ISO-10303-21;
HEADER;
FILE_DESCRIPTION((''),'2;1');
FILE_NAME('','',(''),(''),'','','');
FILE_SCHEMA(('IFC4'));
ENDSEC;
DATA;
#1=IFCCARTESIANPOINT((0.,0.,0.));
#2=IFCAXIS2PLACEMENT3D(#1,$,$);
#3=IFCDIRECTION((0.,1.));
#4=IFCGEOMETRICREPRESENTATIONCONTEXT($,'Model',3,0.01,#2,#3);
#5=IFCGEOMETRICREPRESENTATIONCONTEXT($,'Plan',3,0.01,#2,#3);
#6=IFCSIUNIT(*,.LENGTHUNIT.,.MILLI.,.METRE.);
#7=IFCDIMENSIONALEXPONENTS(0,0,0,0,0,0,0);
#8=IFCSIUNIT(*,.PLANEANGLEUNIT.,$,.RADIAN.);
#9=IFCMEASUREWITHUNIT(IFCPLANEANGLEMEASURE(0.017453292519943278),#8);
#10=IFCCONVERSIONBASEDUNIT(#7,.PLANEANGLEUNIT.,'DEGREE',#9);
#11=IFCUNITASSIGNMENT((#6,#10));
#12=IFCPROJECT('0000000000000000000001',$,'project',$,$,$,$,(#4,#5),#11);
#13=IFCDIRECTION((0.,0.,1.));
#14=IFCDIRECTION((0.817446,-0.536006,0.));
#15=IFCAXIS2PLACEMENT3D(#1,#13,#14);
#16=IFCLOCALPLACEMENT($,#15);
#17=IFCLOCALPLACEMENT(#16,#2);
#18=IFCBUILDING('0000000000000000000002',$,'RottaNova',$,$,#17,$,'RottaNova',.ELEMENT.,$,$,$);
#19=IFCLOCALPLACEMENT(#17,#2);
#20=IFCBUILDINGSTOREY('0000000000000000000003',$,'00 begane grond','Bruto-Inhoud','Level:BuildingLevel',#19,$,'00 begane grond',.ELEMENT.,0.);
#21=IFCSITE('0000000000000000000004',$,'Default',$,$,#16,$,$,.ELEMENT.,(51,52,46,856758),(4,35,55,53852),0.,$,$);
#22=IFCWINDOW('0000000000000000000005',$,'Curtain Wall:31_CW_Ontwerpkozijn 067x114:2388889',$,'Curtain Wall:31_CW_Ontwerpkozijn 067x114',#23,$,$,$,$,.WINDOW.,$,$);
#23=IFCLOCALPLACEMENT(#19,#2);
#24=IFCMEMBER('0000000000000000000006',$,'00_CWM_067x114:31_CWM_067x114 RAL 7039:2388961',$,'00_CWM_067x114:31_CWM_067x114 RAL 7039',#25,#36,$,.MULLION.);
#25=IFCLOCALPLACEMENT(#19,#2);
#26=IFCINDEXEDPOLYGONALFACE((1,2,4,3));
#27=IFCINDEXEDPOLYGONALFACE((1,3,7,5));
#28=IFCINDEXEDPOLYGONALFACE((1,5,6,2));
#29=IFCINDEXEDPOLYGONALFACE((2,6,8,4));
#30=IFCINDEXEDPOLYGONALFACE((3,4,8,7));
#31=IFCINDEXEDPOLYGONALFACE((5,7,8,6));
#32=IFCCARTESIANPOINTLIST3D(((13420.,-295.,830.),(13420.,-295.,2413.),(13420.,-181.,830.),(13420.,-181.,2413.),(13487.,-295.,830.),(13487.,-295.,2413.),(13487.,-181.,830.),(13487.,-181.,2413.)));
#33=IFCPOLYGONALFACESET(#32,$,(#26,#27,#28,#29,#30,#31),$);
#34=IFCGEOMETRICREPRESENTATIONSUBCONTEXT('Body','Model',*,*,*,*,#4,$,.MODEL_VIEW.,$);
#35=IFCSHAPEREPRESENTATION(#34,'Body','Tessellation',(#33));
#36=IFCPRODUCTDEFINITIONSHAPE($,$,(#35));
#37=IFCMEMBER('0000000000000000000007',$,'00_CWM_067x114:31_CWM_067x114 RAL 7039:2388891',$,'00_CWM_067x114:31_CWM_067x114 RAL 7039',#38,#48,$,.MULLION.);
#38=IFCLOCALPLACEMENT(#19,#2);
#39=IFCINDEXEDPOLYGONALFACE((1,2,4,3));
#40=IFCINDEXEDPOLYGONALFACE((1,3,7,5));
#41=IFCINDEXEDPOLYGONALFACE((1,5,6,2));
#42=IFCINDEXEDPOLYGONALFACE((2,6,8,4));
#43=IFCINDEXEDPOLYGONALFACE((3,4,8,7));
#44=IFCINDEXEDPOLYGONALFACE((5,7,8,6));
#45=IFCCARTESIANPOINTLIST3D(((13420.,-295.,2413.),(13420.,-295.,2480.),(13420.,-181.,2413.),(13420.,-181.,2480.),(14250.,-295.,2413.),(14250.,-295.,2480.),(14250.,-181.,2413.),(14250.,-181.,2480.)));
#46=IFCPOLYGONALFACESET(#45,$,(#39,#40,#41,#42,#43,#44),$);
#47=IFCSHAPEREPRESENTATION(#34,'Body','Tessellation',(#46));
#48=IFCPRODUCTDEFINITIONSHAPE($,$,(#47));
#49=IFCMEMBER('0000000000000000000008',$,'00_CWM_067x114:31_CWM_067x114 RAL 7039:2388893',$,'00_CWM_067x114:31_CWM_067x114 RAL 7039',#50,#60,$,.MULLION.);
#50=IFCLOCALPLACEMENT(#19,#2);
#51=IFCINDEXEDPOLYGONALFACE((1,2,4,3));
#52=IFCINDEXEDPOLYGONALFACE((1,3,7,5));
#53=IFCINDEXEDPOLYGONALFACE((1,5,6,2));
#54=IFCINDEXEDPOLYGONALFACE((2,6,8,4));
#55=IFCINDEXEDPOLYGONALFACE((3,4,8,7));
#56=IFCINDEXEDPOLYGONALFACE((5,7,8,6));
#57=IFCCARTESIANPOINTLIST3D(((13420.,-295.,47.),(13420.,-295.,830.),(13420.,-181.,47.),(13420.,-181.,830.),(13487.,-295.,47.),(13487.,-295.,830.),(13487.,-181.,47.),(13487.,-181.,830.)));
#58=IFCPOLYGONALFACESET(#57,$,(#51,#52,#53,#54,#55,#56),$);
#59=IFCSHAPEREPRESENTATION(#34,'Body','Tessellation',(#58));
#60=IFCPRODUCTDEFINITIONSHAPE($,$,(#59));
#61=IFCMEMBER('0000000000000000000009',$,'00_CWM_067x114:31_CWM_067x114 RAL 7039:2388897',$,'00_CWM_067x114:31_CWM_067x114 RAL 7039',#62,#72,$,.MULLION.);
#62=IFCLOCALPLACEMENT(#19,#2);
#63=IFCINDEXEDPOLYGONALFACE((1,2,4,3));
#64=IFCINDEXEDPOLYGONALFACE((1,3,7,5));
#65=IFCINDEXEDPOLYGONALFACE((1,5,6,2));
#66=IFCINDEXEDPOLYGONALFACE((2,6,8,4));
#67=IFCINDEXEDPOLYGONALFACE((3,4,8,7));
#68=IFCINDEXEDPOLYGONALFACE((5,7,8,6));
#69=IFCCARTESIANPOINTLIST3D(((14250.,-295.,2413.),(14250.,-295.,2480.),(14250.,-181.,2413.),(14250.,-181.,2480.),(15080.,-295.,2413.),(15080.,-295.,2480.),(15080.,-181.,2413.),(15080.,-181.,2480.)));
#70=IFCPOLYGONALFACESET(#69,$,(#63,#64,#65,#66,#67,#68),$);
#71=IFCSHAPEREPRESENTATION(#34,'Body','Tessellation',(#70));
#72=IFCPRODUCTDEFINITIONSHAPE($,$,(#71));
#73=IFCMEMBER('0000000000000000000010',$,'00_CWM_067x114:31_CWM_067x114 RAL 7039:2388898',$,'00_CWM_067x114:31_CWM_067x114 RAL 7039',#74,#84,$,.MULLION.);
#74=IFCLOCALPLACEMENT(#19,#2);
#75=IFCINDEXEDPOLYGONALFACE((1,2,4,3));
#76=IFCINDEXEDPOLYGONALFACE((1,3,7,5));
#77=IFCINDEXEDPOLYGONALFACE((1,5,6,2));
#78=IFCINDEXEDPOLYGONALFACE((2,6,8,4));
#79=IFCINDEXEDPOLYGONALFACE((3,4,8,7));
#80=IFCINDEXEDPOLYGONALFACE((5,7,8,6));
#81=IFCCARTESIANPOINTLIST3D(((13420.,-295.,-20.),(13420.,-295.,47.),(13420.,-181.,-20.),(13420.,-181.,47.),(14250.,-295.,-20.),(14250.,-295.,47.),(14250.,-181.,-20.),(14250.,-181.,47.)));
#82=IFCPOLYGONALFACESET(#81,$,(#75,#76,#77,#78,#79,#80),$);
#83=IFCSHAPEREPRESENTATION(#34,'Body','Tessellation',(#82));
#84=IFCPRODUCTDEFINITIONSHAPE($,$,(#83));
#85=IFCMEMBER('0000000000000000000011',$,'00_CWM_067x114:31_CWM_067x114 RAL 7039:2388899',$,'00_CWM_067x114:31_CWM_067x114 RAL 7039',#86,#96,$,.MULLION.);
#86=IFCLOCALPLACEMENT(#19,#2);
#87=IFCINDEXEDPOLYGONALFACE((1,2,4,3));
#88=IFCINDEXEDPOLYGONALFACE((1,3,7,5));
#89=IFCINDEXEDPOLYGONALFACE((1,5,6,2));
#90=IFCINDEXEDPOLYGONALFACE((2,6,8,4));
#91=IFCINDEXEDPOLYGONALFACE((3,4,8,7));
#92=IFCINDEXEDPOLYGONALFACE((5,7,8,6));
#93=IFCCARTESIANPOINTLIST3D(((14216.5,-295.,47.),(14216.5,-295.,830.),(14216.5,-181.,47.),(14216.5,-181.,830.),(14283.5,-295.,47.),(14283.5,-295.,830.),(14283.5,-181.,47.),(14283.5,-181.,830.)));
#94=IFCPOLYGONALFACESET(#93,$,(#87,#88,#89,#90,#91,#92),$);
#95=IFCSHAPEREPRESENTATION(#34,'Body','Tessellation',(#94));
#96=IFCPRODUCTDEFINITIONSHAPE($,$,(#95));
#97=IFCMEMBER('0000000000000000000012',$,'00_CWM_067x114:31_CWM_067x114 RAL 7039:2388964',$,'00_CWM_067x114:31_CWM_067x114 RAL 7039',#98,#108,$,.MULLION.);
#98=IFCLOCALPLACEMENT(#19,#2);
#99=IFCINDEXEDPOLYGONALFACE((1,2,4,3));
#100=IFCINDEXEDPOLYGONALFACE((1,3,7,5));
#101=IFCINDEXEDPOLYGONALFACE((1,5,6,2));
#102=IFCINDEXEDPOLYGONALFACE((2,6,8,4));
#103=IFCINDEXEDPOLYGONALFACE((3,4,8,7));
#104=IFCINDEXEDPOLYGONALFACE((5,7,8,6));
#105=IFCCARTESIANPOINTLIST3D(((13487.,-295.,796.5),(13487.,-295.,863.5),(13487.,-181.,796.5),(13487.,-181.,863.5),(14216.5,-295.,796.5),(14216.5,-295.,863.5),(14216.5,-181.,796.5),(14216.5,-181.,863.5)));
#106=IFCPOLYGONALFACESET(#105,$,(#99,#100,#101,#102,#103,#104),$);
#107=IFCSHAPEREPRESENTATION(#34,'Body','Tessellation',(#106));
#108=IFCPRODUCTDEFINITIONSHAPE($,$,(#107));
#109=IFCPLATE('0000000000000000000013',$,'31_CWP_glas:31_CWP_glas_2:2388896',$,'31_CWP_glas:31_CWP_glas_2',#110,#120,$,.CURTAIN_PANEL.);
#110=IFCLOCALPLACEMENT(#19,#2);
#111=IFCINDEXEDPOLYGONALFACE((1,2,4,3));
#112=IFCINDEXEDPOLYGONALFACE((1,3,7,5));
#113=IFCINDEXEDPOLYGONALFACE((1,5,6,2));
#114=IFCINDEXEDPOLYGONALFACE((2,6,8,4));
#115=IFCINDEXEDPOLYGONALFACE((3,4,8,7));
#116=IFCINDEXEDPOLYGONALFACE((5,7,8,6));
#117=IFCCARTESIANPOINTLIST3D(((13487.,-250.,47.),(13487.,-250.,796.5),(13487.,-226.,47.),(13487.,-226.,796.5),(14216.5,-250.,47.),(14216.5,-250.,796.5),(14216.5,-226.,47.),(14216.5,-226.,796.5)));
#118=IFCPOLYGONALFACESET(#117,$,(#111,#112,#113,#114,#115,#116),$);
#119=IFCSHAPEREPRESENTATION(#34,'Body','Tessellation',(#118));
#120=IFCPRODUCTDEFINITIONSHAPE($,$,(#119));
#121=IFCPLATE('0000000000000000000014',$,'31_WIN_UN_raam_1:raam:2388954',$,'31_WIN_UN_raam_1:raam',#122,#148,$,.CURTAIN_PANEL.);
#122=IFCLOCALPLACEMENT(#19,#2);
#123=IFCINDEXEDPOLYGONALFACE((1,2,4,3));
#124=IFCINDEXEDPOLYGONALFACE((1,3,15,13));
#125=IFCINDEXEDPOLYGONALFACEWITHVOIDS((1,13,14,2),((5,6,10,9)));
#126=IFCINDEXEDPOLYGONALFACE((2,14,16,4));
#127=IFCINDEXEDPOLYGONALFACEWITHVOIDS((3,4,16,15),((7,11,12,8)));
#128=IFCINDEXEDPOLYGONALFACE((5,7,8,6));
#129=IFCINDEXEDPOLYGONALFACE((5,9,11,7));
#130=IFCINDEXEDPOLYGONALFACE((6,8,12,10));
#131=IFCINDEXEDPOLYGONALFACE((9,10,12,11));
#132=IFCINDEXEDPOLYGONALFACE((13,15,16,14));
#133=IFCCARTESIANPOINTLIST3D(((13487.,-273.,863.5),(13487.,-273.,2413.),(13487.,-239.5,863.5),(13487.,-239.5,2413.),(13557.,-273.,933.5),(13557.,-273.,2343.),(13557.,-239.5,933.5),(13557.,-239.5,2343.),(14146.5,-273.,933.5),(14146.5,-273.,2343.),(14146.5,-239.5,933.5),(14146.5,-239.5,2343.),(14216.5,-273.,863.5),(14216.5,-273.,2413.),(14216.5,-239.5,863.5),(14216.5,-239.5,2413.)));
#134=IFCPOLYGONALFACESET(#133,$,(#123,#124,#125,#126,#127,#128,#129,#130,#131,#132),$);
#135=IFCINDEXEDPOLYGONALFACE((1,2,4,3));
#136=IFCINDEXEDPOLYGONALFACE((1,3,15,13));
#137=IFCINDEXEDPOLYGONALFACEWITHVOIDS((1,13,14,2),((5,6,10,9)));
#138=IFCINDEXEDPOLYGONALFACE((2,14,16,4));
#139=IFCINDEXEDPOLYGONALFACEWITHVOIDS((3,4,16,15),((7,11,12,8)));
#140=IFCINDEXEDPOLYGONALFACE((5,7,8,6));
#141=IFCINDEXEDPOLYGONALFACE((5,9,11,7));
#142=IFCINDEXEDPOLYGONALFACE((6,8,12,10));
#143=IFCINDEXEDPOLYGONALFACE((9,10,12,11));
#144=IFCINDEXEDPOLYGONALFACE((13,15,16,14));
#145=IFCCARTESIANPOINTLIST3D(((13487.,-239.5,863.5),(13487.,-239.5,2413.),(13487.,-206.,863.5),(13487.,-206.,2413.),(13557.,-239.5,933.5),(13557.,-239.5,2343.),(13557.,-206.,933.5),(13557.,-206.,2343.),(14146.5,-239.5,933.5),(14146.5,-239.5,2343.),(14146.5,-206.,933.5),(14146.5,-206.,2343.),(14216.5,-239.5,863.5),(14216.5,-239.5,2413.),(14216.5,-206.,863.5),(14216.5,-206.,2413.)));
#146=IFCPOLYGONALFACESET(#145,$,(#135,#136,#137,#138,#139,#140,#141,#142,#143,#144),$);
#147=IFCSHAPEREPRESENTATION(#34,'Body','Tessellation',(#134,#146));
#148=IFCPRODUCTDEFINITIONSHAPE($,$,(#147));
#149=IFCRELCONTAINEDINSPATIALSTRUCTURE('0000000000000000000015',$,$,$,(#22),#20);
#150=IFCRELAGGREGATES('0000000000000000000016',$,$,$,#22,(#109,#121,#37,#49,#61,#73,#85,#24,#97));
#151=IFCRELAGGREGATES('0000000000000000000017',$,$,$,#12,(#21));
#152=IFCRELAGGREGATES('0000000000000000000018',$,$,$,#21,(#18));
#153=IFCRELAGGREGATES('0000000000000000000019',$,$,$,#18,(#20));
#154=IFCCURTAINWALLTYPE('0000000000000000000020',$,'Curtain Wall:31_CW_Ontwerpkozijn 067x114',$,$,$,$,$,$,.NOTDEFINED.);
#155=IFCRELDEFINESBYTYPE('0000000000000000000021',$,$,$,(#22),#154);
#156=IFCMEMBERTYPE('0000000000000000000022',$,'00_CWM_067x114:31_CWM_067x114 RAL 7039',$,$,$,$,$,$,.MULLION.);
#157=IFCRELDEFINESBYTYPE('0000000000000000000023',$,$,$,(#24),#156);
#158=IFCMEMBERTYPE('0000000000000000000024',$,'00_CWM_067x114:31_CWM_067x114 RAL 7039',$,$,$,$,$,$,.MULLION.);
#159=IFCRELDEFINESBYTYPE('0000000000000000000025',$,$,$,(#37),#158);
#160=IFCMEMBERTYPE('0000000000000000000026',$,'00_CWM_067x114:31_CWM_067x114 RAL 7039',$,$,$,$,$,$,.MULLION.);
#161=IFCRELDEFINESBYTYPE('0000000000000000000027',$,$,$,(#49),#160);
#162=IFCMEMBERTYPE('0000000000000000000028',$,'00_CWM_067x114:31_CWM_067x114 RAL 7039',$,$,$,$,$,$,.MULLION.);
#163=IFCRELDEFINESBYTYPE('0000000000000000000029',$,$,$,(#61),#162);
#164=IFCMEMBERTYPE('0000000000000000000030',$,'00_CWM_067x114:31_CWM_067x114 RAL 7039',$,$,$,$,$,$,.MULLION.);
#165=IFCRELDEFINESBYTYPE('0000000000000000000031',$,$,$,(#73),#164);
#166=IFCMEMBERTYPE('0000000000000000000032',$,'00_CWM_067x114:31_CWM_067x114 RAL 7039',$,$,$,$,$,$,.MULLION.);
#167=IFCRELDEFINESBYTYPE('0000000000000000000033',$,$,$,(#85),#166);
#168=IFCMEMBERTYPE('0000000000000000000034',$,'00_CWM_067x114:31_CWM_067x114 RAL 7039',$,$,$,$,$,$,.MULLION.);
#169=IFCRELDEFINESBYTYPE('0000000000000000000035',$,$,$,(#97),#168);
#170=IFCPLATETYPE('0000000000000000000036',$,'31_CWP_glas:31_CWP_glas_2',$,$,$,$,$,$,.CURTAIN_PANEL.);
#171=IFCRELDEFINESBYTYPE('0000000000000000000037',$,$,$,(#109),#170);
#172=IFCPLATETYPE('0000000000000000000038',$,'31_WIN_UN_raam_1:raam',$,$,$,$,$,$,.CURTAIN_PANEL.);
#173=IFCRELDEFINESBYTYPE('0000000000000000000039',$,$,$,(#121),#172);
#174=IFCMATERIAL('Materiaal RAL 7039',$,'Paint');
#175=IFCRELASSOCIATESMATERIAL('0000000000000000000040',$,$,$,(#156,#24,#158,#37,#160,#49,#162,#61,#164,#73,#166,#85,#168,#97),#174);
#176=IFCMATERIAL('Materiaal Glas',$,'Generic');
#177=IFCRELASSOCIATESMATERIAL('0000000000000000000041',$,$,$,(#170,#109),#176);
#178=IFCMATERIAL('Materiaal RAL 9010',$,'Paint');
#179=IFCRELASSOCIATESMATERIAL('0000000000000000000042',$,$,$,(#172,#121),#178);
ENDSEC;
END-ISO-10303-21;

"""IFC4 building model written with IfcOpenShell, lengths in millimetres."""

from ifc_helpers import new_model, entity, si_unit, converted_unit, direction, frame, origin, place, context, subcontext, project, spatial, indexed_curve, outline, extrude, source, transform, mapped, material, type_object, type_shapes, element, aggregate, save


model = new_model("IFC4")

# Units and contexts
model_context = context("Model", 3, precision=0.01, world=origin(), true_north=direction((0.0, 1.0)))
plan_context = context("Plan", 3, precision=0.01, world=origin(), true_north=direction((0.0, 1.0)))
body_context = subcontext(model_context, "Body", "Model", "MODEL_VIEW")
ifc_project = project(units=[si_unit("LENGTHUNIT", "METRE", prefix="MILLI"), converted_unit("PLANEANGLEUNIT", "DEGREE", entity("IfcPlaneAngleMeasure", 0.017453292519943278), si_unit("PLANEANGLEUNIT", "RADIAN"), dimensions=[0, 0, 0, 0, 0, 0, 0])], contexts=[model_context, plan_context])

# Site, building, storey
site_placement = place(None, frame((0.0, 0.0, 0.0), z_axis=(0.0, 0.0, 1.0), x_axis=(0.817446, -0.536006, 0.0)))
site = spatial("IfcSite", under=ifc_project, at=site_placement, Name="Default", CompositionType="ELEMENT", RefLatitude=(51, 52, 46, 856758), RefLongitude=(4, 35, 55, 53852), RefElevation=0.0)
building_placement = place(site_placement, origin())
building = spatial("IfcBuilding", under=site, at=building_placement, Name="RottaNova", LongName="RottaNova", CompositionType="ELEMENT")
storey_placement = place(building_placement, origin())
storey = spatial("IfcBuildingStorey", under=building, at=storey_placement, Name="00 begane grond", Description="Bruto-Inhoud", ObjectType="Level:BuildingLevel", LongName="00 begane grond", CompositionType="ELEMENT", Elevation=0.0)

# Window, members, plates
curtain_wall_type = type_object("IfcCurtainWallType", Name="Curtain Wall:31_CW_Ontwerpkozijn 067x114", PredefinedType="NOTDEFINED")
window_1_placement = place(storey_placement, origin())
window_1 = element("IfcWindow", 1, at=window_1_placement, inside=storey, type_object=curtain_wall_type, Name="Curtain Wall:31_CW_Ontwerpkozijn 067x114:2388889", ObjectType="Curtain Wall:31_CW_Ontwerpkozijn 067x114", PredefinedType="WINDOW")
ifc_material_1 = material(Name="Materiaal RAL 7039", Category="Paint")
member_type_1 = type_object("IfcMemberType", Name="00_CWM_067x114:31_CWM_067x114 RAL 7039", PredefinedType="MULLION", material=ifc_material_1)
shared_shape_1 = source(origin(), body_context, "Body", "SweptSolid", [
    extrude(outline(indexed_curve([(-33.5, -57.0), (33.5, -57.0), (33.5, 57.0), (-33.5, 57.0), (-33.5, -57.0)], self_intersect=False)), frame((-33.5, -57.0, -1583.0), z_axis=(0.0, 0.0, 1.0), x_axis=(-1.0, 0.0, 0.0)), (0.0, 0.0, 1.0), 1583.0),
])
type_shapes(member_type_1, [shared_shape_1])
member_1_placement = place(window_1_placement, frame((13420.0, -181.0, 830.0), z_axis=(0.0, 0.0, -1.0), x_axis=(-1.0, 0.0, 0.0)))
member_1 = element("IfcMember", 2, at=member_1_placement, type_object=member_type_1, material=ifc_material_1, Name="00_CWM_067x114:31_CWM_067x114 RAL 7039:2388961", ObjectType="00_CWM_067x114:31_CWM_067x114 RAL 7039", PredefinedType="MULLION", context=body_context, shape_type="MappedRepresentation", body=[
    mapped(shared_shape_1, transform((0.0, 0.0, 0.0), scale=1.0)),
])
member_type_2 = type_object("IfcMemberType", Name="00_CWM_067x114:31_CWM_067x114 RAL 7039", PredefinedType="MULLION", material=ifc_material_1)
shared_shape_2 = source(origin(), body_context, "Body", "SweptSolid", [
    extrude(outline(indexed_curve([(-33.5, -57.0), (33.5, -57.0), (33.5, 57.0), (-33.5, 57.0), (-33.5, -57.0)], self_intersect=False)), frame((-33.5, -57.0, -830.0), z_axis=(0.0, 0.0, 1.0), x_axis=(-1.0, 0.0, 0.0)), (0.0, 0.0, 1.0), 830.0),
])
type_shapes(member_type_2, [shared_shape_2])
member_2_placement = place(window_1_placement, frame((13420.0, -181.0, 2480.0), z_axis=(-1.0, 0.0, 0.0), x_axis=(0.0, 0.0, 1.0)))
member_2 = element("IfcMember", 3, at=member_2_placement, type_object=member_type_2, material=ifc_material_1, Name="00_CWM_067x114:31_CWM_067x114 RAL 7039:2388891", ObjectType="00_CWM_067x114:31_CWM_067x114 RAL 7039", PredefinedType="MULLION", context=body_context, shape_type="MappedRepresentation", body=[
    mapped(shared_shape_2, transform((0.0, 0.0, 0.0), scale=1.0)),
])
member_type_3 = type_object("IfcMemberType", Name="00_CWM_067x114:31_CWM_067x114 RAL 7039", PredefinedType="MULLION", material=ifc_material_1)
shared_shape_3 = source(origin(), body_context, "Body", "SweptSolid", [
    extrude(outline(indexed_curve([(-33.5, -57.0), (33.5, -57.0), (33.5, 57.0), (-33.5, 57.0), (-33.5, -57.0)], self_intersect=False)), frame((-33.5, -57.0, -783.0), z_axis=(0.0, 0.0, 1.0), x_axis=(-1.0, 0.0, 0.0)), (0.0, 0.0, 1.0), 783.0),
])
type_shapes(member_type_3, [shared_shape_3])
member_3_placement = place(window_1_placement, frame((13420.0, -181.0, 47.0), z_axis=(0.0, 0.0, -1.0), x_axis=(-1.0, 0.0, 0.0)))
member_3 = element("IfcMember", 4, at=member_3_placement, type_object=member_type_3, material=ifc_material_1, Name="00_CWM_067x114:31_CWM_067x114 RAL 7039:2388893", ObjectType="00_CWM_067x114:31_CWM_067x114 RAL 7039", PredefinedType="MULLION", context=body_context, shape_type="MappedRepresentation", body=[
    mapped(shared_shape_3, transform((0.0, 0.0, 0.0), scale=1.0)),
])
member_type_4 = type_object("IfcMemberType", Name="00_CWM_067x114:31_CWM_067x114 RAL 7039", PredefinedType="MULLION", material=ifc_material_1)
shared_shape_4 = source(origin(), body_context, "Body", "SweptSolid", [
    extrude(outline(indexed_curve([(-33.5, -57.0), (33.5, -57.0), (33.5, 57.0), (-33.5, 57.0), (-33.5, -57.0)], self_intersect=False)), frame((-33.5, -57.0, -830.0), z_axis=(0.0, 0.0, 1.0), x_axis=(-1.0, 0.0, 0.0)), (0.0, 0.0, 1.0), 830.0),
])
type_shapes(member_type_4, [shared_shape_4])
member_4_placement = place(window_1_placement, frame((14250.0, -181.0, 2480.0), z_axis=(-1.0, 0.0, 0.0), x_axis=(0.0, 0.0, 1.0)))
member_4 = element("IfcMember", 5, at=member_4_placement, type_object=member_type_4, material=ifc_material_1, Name="00_CWM_067x114:31_CWM_067x114 RAL 7039:2388897", ObjectType="00_CWM_067x114:31_CWM_067x114 RAL 7039", PredefinedType="MULLION", context=body_context, shape_type="MappedRepresentation", body=[
    mapped(shared_shape_4, transform((0.0, 0.0, 0.0), scale=1.0)),
])
member_type_5 = type_object("IfcMemberType", Name="00_CWM_067x114:31_CWM_067x114 RAL 7039", PredefinedType="MULLION", material=ifc_material_1)
shared_shape_5 = source(origin(), body_context, "Body", "SweptSolid", [
    extrude(outline(indexed_curve([(-33.5, -57.0), (33.5, -57.0), (33.5, 57.0), (-33.5, 57.0), (-33.5, -57.0)], self_intersect=False)), frame((-33.5, -57.0, -830.0), z_axis=(0.0, 0.0, 1.0), x_axis=(-1.0, 0.0, 0.0)), (0.0, 0.0, 1.0), 830.0),
])
type_shapes(member_type_5, [shared_shape_5])
member_5_placement = place(window_1_placement, frame((14250.0, -181.0, -20.0), z_axis=(1.0, 0.0, 0.0), x_axis=(0.0, 0.0, -1.0)))
member_5 = element("IfcMember", 6, at=member_5_placement, type_object=member_type_5, material=ifc_material_1, Name="00_CWM_067x114:31_CWM_067x114 RAL 7039:2388898", ObjectType="00_CWM_067x114:31_CWM_067x114 RAL 7039", PredefinedType="MULLION", context=body_context, shape_type="MappedRepresentation", body=[
    mapped(shared_shape_5, transform((0.0, 0.0, 0.0), scale=1.0)),
])
member_type_6 = type_object("IfcMemberType", Name="00_CWM_067x114:31_CWM_067x114 RAL 7039", PredefinedType="MULLION", material=ifc_material_1)
shared_shape_6 = source(origin(), body_context, "Body", "SweptSolid", [
    extrude(outline(indexed_curve([(-33.5, -57.0), (33.5, -57.0), (33.5, 57.0), (-33.5, 57.0), (-33.5, -57.0)], self_intersect=False)), frame((0.0, -57.0, -783.0), z_axis=(0.0, 0.0, 1.0), x_axis=(-1.0, 0.0, 0.0)), (0.0, 0.0, 1.0), 783.0),
])
type_shapes(member_type_6, [shared_shape_6])
member_6_placement = place(window_1_placement, frame((14250.0, -181.0, 47.0), z_axis=(0.0, 0.0, -1.0), x_axis=(-1.0, 0.0, 0.0)))
member_6 = element("IfcMember", 7, at=member_6_placement, type_object=member_type_6, material=ifc_material_1, Name="00_CWM_067x114:31_CWM_067x114 RAL 7039:2388899", ObjectType="00_CWM_067x114:31_CWM_067x114 RAL 7039", PredefinedType="MULLION", context=body_context, shape_type="MappedRepresentation", body=[
    mapped(shared_shape_6, transform((0.0, 0.0, 0.0), scale=1.0)),
])
member_type_7 = type_object("IfcMemberType", Name="00_CWM_067x114:31_CWM_067x114 RAL 7039", PredefinedType="MULLION", material=ifc_material_1)
shared_shape_7 = source(origin(), body_context, "Body", "SweptSolid", [
    extrude(outline(indexed_curve([(-33.5, -57.0), (33.5, -57.0), (33.5, 57.0), (-33.5, 57.0), (-33.5, -57.0)], self_intersect=False)), frame((0.0, -57.0, -729.5), z_axis=(0.0, 0.0, 1.0), x_axis=(-1.0, 0.0, 0.0)), (0.0, 0.0, 1.0), 729.5),
])
type_shapes(member_type_7, [shared_shape_7])
member_7_placement = place(window_1_placement, frame((13487.0, -181.0, 830.0), z_axis=(-1.0, 0.0, 0.0), x_axis=(0.0, 0.0, 1.0)))
member_7 = element("IfcMember", 8, at=member_7_placement, type_object=member_type_7, material=ifc_material_1, Name="00_CWM_067x114:31_CWM_067x114 RAL 7039:2388964", ObjectType="00_CWM_067x114:31_CWM_067x114 RAL 7039", PredefinedType="MULLION", context=body_context, shape_type="MappedRepresentation", body=[
    mapped(shared_shape_7, transform((0.0, 0.0, 0.0), scale=1.0)),
])
ifc_material_2 = material(Name="Materiaal Glas", Category="Generic")
plate_type_1 = type_object("IfcPlateType", Name="31_CWP_glas:31_CWP_glas_2", PredefinedType="CURTAIN_PANEL", material=ifc_material_2)
shared_shape_8 = source(origin(), body_context, "Body", "SweptSolid", [
    extrude(outline(indexed_curve([(-12.0, -364.7), (12.0, -364.7), (12.0, 364.7), (-12.0, 364.7), (-12.0, -364.7)], self_intersect=False)), frame((0.0, 57.0, 0.0), z_axis=(0.0, 0.0, 1.0), x_axis=(0.0, 1.0, 0.0)), (0.0, 0.0, 1.0), 749.5),
])
type_shapes(plate_type_1, [shared_shape_8])
plate_1_placement = place(window_1_placement, frame((13851.8, -181.0, 47.0), z_axis=(0.0, 0.0, 1.0), x_axis=(-1.0, 0.0, 0.0)))
plate_1 = element("IfcPlate", 9, at=plate_1_placement, type_object=plate_type_1, material=ifc_material_2, Name="31_CWP_glas:31_CWP_glas_2:2388896", ObjectType="31_CWP_glas:31_CWP_glas_2", PredefinedType="CURTAIN_PANEL", context=body_context, shape_type="MappedRepresentation", body=[
    mapped(shared_shape_8, transform((0.0, 0.0, 0.0), scale=1.0)),
])
ifc_material_3 = material(Name="Materiaal RAL 9010", Category="Paint")
plate_type_2 = type_object("IfcPlateType", Name="31_WIN_UN_raam_1:raam", PredefinedType="CURTAIN_PANEL", material=ifc_material_3)
shared_shape_9 = source(origin(), body_context, "Body", "SweptSolid", [
    extrude(outline(indexed_curve([(-364.7, -774.7), (364.7, -774.7), (364.7, 774.7), (-364.7, 774.7), (-364.7, -774.7)], self_intersect=False), holes=[indexed_curve([(-294.7, 704.7), (294.7, 704.7), (294.7, -704.8), (-294.7, -704.8), (-294.7, 704.7)], self_intersect=False)]), frame((0.0, 58.5, 774.8), z_axis=(0.0, 1.0, 0.0), x_axis=(1.0, 0.0, 0.0)), (0.0, 0.0, 1.0), 33.5),
    extrude(outline(indexed_curve([(-364.7, -774.7), (364.7, -774.7), (364.7, 774.7), (-364.7, 774.7), (-364.7, -774.7)], self_intersect=False), holes=[indexed_curve([(-294.7, 704.7), (294.7, 704.7), (294.7, -704.8), (-294.7, -704.8), (-294.7, 704.7)], self_intersect=False)]), frame((0.0, 25.0, 774.8), z_axis=(0.0, 1.0, 0.0), x_axis=(1.0, 0.0, 0.0)), (0.0, 0.0, 1.0), 33.5),
])
type_shapes(plate_type_2, [shared_shape_9])
plate_2_placement = place(window_1_placement, frame((13851.8, -181.0, 863.5), z_axis=(0.0, 0.0, 1.0), x_axis=(-1.0, 0.0, 0.0)))
plate_2 = element("IfcPlate", 10, at=plate_2_placement, type_object=plate_type_2, material=ifc_material_3, Name="31_WIN_UN_raam_1:raam:2388954", ObjectType="31_WIN_UN_raam_1:raam", PredefinedType="CURTAIN_PANEL", context=body_context, shape_type="MappedRepresentation", body=[
    mapped(shared_shape_9, transform((0.0, 0.0, 0.0), scale=1.0)),
])
aggregate(window_1, [plate_1, plate_2, member_2, member_3, member_4, member_5, member_6, member_1, member_7])

save(model, "model.ifc")
